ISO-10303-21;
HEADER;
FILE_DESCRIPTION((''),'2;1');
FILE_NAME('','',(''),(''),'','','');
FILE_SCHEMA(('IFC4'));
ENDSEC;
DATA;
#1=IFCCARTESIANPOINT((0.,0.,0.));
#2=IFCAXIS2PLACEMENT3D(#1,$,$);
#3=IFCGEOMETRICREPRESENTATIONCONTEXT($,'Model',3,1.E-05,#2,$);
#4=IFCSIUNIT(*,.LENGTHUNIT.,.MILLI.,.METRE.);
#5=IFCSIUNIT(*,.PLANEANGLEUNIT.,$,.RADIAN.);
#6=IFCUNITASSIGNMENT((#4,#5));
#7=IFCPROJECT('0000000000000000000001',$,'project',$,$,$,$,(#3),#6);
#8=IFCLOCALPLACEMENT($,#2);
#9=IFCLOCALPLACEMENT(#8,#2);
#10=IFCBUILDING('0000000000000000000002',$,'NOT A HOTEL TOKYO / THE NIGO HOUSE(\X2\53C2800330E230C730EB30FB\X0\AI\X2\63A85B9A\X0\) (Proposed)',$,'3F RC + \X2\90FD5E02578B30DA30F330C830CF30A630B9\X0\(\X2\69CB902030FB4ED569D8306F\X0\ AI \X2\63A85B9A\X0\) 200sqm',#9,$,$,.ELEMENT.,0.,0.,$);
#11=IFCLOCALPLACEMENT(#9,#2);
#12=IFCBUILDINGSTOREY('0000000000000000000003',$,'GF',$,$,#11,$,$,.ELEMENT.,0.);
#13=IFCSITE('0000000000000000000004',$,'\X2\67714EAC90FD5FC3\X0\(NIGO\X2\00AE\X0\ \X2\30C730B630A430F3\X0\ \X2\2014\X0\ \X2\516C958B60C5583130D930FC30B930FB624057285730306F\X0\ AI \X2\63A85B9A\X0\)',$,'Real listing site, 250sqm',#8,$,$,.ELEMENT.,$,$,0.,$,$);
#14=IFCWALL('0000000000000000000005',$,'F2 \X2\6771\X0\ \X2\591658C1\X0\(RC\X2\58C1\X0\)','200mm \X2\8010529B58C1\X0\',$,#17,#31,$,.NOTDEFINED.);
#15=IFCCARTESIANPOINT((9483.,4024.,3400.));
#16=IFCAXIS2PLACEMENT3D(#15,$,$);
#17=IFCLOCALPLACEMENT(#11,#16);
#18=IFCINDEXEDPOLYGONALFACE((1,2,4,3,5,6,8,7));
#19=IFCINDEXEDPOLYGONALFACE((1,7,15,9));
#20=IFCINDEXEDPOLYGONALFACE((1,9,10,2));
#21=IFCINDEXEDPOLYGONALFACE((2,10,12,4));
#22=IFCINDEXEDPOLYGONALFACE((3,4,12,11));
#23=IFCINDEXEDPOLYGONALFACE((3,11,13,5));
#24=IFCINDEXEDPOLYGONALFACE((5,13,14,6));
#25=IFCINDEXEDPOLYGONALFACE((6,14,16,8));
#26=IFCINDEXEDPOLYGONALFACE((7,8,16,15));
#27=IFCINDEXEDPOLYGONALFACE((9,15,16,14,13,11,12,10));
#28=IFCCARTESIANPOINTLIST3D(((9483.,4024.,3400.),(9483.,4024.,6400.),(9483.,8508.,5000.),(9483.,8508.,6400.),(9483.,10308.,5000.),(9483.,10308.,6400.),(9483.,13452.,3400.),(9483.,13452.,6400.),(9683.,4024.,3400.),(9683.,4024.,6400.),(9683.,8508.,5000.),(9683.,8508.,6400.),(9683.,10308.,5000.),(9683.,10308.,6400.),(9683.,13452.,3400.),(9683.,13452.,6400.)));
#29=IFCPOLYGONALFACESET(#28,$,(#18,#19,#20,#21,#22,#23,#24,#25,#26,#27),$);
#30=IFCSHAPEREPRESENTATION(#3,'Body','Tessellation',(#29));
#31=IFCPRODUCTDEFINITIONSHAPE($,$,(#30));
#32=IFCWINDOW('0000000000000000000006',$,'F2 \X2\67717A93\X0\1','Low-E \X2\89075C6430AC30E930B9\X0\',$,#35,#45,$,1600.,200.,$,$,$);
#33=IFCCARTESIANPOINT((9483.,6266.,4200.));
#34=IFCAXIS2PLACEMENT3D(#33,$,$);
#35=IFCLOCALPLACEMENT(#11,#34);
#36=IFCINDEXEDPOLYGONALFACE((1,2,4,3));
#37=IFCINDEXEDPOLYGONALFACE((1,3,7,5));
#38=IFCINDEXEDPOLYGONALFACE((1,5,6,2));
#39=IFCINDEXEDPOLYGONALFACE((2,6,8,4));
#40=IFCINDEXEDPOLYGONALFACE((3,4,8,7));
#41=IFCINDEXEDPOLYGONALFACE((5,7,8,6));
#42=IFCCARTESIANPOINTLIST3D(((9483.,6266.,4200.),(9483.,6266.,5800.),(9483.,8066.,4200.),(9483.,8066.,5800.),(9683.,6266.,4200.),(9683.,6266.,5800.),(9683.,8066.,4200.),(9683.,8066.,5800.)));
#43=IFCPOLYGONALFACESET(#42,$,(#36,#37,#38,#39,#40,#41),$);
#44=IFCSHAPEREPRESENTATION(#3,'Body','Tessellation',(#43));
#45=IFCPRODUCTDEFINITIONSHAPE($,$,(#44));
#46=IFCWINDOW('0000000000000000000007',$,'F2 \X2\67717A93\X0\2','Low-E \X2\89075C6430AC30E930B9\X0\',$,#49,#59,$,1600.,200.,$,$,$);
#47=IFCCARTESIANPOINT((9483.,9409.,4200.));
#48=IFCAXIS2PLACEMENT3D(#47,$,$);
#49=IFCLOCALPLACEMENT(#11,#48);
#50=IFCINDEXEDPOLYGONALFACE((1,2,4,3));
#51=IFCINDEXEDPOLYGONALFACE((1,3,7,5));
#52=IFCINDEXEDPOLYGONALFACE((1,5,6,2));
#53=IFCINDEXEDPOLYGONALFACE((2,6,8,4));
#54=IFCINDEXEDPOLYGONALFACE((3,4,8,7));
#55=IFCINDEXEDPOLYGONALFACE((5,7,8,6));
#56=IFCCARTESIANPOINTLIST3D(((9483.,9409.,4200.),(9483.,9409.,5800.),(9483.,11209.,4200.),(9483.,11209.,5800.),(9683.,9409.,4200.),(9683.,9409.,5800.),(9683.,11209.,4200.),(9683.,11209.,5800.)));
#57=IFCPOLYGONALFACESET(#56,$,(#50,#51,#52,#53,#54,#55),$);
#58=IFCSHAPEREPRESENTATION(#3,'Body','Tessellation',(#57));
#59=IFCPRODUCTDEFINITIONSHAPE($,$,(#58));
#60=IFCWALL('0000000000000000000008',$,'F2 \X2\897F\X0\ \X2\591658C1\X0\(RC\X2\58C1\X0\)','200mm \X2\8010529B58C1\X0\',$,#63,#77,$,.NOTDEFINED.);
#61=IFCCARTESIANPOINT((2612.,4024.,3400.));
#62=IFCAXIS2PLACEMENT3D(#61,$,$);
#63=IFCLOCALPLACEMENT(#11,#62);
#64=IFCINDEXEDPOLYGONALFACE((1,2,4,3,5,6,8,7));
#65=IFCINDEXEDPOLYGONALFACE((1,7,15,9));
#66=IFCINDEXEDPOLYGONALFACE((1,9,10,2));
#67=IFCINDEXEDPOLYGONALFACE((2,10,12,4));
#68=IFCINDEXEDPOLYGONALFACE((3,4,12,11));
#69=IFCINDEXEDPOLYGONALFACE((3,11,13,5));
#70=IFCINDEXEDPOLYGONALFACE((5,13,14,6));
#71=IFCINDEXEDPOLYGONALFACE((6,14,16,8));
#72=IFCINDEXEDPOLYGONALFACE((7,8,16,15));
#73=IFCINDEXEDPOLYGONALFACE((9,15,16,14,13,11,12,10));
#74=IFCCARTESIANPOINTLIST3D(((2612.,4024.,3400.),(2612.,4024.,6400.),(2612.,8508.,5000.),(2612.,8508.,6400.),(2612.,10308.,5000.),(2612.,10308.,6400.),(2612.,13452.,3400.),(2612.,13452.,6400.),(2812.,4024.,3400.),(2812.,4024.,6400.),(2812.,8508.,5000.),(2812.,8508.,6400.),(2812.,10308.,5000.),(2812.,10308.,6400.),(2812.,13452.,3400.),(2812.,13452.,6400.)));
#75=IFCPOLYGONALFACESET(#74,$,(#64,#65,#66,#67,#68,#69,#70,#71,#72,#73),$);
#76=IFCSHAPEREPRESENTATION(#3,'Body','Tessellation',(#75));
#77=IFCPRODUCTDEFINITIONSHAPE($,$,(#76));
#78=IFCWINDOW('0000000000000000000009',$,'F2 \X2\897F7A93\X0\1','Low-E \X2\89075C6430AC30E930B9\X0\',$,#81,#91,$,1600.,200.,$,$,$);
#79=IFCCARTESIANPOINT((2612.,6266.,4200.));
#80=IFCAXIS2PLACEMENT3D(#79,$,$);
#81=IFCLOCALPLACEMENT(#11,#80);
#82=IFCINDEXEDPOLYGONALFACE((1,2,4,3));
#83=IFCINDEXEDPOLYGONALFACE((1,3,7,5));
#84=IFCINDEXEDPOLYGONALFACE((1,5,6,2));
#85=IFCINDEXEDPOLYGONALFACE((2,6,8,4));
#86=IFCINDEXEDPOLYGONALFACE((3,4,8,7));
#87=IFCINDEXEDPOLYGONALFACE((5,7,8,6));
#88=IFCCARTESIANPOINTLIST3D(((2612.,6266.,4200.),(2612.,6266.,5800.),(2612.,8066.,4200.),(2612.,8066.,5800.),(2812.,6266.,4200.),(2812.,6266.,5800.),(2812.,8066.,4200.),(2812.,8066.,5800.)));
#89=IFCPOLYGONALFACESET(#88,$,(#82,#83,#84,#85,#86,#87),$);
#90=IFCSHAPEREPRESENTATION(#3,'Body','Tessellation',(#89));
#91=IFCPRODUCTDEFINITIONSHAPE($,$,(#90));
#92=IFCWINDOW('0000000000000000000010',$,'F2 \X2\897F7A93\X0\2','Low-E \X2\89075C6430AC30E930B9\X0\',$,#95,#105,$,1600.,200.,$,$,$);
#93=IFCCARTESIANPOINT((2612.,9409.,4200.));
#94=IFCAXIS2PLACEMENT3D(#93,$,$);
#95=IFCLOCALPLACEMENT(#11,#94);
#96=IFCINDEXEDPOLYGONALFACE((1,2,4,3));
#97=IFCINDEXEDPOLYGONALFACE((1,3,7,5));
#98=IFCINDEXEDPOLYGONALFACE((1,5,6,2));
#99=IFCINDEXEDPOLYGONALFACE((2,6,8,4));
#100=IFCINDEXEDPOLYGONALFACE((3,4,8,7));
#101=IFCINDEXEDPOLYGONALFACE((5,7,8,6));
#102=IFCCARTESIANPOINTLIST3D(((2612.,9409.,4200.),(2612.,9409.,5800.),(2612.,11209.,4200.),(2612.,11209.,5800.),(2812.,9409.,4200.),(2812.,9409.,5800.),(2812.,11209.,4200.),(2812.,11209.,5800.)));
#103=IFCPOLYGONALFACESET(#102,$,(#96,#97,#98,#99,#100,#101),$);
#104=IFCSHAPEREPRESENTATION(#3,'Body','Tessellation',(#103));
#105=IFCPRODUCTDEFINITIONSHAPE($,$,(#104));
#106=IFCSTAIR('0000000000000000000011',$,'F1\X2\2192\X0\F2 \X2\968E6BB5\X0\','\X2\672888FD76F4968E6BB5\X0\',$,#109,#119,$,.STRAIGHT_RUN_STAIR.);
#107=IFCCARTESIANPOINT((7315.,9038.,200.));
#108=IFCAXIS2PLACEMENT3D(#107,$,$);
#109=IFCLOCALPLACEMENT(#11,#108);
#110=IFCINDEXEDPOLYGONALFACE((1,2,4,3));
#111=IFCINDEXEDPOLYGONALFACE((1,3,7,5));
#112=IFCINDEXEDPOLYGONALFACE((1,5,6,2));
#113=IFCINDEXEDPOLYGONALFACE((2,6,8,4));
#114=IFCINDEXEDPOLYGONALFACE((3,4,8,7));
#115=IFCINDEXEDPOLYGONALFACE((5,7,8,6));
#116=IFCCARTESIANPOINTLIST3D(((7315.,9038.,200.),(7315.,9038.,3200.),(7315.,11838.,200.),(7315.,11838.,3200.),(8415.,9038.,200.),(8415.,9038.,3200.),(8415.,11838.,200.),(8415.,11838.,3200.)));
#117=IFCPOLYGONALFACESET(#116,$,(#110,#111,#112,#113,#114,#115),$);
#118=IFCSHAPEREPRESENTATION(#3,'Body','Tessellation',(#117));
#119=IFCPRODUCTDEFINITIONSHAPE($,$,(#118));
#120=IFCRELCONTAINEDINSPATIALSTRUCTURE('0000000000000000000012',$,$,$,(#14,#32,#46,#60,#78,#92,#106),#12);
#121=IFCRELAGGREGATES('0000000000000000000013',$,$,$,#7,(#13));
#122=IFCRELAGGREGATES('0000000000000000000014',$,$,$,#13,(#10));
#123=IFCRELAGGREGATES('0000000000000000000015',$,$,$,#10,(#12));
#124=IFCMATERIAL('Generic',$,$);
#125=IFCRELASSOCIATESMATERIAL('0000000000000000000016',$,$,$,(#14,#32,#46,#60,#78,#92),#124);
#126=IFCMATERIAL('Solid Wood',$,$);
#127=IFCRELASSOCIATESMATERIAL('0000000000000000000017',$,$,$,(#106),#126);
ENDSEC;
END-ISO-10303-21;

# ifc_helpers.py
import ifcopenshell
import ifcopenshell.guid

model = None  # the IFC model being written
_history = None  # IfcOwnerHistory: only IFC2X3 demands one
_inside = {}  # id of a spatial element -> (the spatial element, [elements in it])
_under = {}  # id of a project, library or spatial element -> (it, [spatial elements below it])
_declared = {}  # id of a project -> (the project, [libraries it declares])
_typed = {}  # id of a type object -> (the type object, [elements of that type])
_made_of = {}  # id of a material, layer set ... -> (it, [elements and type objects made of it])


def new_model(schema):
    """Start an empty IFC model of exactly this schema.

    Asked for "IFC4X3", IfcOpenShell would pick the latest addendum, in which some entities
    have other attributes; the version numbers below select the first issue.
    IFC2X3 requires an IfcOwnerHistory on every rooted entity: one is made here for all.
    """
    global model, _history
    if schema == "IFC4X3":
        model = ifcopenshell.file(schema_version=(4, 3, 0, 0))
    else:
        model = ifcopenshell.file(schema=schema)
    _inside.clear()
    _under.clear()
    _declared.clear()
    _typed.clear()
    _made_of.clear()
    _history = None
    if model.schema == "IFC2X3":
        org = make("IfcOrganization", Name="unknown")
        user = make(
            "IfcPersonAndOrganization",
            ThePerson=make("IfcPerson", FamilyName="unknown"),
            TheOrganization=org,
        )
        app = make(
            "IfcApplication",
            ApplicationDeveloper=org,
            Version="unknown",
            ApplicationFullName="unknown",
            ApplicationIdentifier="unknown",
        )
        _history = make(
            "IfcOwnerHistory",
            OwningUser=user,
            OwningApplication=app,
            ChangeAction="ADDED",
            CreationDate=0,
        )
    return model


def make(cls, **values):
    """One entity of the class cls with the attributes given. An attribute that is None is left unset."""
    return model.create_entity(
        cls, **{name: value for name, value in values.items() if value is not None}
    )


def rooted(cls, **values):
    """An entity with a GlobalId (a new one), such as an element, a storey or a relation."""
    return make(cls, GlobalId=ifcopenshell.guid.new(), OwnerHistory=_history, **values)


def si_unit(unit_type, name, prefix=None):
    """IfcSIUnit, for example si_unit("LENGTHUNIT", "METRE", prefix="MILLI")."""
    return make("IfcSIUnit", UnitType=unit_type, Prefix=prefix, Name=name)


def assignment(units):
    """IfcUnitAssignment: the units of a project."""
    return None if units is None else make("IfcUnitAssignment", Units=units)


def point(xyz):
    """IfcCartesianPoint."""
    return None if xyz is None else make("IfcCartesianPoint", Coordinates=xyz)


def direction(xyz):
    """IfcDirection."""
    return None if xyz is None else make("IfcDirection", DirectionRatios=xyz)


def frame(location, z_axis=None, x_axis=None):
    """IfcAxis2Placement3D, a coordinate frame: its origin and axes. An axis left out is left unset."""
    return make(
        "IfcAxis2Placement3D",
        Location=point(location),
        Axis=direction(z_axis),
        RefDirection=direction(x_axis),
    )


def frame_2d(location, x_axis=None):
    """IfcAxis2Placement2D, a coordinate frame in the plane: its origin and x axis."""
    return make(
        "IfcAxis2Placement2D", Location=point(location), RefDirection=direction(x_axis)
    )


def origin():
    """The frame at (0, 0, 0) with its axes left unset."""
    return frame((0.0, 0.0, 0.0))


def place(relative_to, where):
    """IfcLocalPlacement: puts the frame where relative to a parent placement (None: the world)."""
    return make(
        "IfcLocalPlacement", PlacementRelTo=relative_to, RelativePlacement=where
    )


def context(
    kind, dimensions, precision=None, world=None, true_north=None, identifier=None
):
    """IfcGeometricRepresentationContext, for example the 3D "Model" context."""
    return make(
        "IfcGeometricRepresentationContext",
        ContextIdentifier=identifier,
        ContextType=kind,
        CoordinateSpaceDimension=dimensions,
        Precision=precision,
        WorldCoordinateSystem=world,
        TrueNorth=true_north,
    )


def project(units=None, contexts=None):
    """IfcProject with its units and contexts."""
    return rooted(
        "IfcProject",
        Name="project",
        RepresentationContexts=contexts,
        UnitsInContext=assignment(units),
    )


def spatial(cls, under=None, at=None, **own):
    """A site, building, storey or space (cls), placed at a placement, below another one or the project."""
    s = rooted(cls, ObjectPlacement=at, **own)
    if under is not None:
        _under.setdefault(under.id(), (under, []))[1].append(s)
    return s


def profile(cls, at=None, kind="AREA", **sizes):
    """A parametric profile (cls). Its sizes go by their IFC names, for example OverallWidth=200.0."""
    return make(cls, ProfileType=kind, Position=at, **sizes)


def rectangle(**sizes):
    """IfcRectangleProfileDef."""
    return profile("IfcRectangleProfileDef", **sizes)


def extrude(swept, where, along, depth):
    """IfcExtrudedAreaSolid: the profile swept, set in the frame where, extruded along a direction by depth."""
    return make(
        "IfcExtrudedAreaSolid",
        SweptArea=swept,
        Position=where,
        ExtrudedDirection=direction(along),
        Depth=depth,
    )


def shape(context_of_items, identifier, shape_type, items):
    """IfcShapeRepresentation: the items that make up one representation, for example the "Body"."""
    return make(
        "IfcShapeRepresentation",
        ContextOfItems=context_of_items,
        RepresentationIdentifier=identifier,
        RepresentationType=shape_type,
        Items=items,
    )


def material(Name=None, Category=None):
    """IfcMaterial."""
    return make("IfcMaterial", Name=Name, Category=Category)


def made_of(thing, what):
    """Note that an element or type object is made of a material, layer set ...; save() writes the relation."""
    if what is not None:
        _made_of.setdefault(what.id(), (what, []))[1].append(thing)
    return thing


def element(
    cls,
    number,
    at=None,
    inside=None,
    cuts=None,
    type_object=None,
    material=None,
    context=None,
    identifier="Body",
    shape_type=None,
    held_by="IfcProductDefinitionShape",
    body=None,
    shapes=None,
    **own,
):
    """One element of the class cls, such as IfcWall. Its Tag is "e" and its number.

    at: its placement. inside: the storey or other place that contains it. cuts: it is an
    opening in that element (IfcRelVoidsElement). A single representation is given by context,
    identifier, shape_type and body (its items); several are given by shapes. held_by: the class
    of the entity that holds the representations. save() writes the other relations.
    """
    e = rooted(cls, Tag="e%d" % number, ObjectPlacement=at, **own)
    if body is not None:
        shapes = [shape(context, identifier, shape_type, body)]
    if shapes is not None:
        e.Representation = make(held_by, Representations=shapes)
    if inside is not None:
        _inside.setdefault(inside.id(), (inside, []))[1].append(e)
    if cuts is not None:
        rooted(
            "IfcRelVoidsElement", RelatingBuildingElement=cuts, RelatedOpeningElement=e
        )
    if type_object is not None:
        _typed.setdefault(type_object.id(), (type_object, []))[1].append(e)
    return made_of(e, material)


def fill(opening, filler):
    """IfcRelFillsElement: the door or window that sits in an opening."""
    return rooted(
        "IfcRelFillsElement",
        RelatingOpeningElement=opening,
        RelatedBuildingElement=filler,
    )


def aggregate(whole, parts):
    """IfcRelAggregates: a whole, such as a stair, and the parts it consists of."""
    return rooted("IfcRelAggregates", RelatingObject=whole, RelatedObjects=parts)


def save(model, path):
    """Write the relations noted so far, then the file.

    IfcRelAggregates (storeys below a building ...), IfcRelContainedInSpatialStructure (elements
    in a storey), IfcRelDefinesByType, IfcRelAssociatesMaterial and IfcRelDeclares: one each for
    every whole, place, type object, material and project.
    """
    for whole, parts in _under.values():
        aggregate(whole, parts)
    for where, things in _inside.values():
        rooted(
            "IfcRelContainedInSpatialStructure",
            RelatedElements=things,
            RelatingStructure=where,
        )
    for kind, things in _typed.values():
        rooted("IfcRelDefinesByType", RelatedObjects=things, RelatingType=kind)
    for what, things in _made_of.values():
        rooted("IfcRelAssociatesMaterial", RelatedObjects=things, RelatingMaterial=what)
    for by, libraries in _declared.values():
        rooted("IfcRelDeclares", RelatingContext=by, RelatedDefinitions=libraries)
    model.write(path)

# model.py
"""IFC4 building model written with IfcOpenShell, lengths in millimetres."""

from ifc_helpers import new_model, si_unit, frame, frame_2d, origin, place, context, project, spatial, rectangle, extrude, material, element, fill, save


model = new_model("IFC4")

# Units and contexts
model_context = context("Model", 3, precision=1e-05, world=origin())
ifc_project = project(units=[si_unit("LENGTHUNIT", "METRE", prefix="MILLI"), si_unit("PLANEANGLEUNIT", "RADIAN")], contexts=[model_context])

# Site, building, storey
site_placement = place(None, origin())
site = spatial("IfcSite", under=ifc_project, at=site_placement, Name="東京都心(NIGO® デザイン — 公開情報ベース・所在地は AI 推定)", ObjectType="Real listing site, 250sqm", CompositionType="ELEMENT", RefElevation=0.0)
building_placement = place(site_placement, origin())
building = spatial("IfcBuilding", under=site, at=building_placement, Name="NOT A HOTEL TOKYO / THE NIGO HOUSE(参考モデル・AI推定) (Proposed)", ObjectType="3F RC + 都市型ペントハウス(構造・仕様は AI 推定) 200sqm", CompositionType="ELEMENT", ElevationOfRefHeight=0.0, ElevationOfTerrain=0.0)
storey_placement = place(building_placement, origin())
storey = spatial("IfcBuildingStorey", under=building, at=storey_placement, Name="GF", CompositionType="ELEMENT", Elevation=0.0)

# Shared definitions
ifc_material_1 = material(Name="Generic")

# Walls, openings, windows
wall_1_placement = place(storey_placement, frame((9483.0, 4024.0, 3400.0)))
wall_1 = element("IfcWall", 1, at=wall_1_placement, inside=storey, material=ifc_material_1, Name="F2 東 外壁(RC壁)", Description="200mm 耐力壁", PredefinedType="NOTDEFINED", context=model_context, shape_type="SweptSolid", body=[
    extrude(rectangle(XDim=200.0, YDim=9428.0, at=frame_2d((100.0, 4714.0))), frame((9483.0, 4024.0, 3400.0)), (0.0, 0.0, 1.0), 3000.0),
])
opening_1_placement = place(storey_placement, frame((9483.0, 6266.0, 4200.0)))
opening_1 = element("IfcOpeningElement", 2, at=opening_1_placement, cuts=wall_1, PredefinedType="NOTDEFINED", context=model_context, shape_type="SweptSolid", body=[
    extrude(rectangle(XDim=200.0, YDim=1800.0, at=frame_2d((100.0, 900.0))), frame((9483.0, 6266.0, 4200.0)), (0.0, 0.0, 1.0), 1600.0),
])
opening_2_placement = place(storey_placement, frame((9483.0, 9409.0, 4200.0)))
opening_2 = element("IfcOpeningElement", 3, at=opening_2_placement, cuts=wall_1, PredefinedType="NOTDEFINED", context=model_context, shape_type="SweptSolid", body=[
    extrude(rectangle(XDim=200.0, YDim=1800.0, at=frame_2d((100.0, 900.0))), frame((9483.0, 9409.0, 4200.0)), (0.0, 0.0, 1.0), 1600.0),
])
window_1_placement = place(storey_placement, frame((9483.0, 6266.0, 4200.0)))
window_1 = element("IfcWindow", 4, at=window_1_placement, inside=storey, material=ifc_material_1, Name="F2 東窓1", Description="Low-E 複層ガラス", OverallHeight=1600.0, OverallWidth=200.0, context=model_context, shape_type="SweptSolid", body=[
    extrude(rectangle(XDim=200.0, YDim=1800.0, at=frame_2d((100.0, 900.0))), frame((9483.0, 6266.0, 4200.0)), (0.0, 0.0, 1.0), 1600.0),
])
fill(opening_1, window_1)
window_2_placement = place(storey_placement, frame((9483.0, 9409.0, 4200.0)))
window_2 = element("IfcWindow", 5, at=window_2_placement, inside=storey, material=ifc_material_1, Name="F2 東窓2", Description="Low-E 複層ガラス", OverallHeight=1600.0, OverallWidth=200.0, context=model_context, shape_type="SweptSolid", body=[
    extrude(rectangle(XDim=200.0, YDim=1800.0, at=frame_2d((100.0, 900.0))), frame((9483.0, 9409.0, 4200.0)), (0.0, 0.0, 1.0), 1600.0),
])
fill(opening_2, window_2)
wall_2_placement = place(storey_placement, frame((2612.0, 4024.0, 3400.0)))
wall_2 = element("IfcWall", 6, at=wall_2_placement, inside=storey, material=ifc_material_1, Name="F2 西 外壁(RC壁)", Description="200mm 耐力壁", PredefinedType="NOTDEFINED", context=model_context, shape_type="SweptSolid", body=[
    extrude(rectangle(XDim=200.0, YDim=9428.0, at=frame_2d((100.0, 4714.0))), frame((2612.0, 4024.0, 3400.0)), (0.0, 0.0, 1.0), 3000.0),
])
opening_3_placement = place(storey_placement, frame((2612.0, 6266.0, 4200.0)))
opening_3 = element("IfcOpeningElement", 7, at=opening_3_placement, cuts=wall_2, PredefinedType="NOTDEFINED", context=model_context, shape_type="SweptSolid", body=[
    extrude(rectangle(XDim=200.0, YDim=1800.0, at=frame_2d((100.0, 900.0))), frame((2612.0, 6266.0, 4200.0)), (0.0, 0.0, 1.0), 1600.0),
])
opening_4_placement = place(storey_placement, frame((2612.0, 9409.0, 4200.0)))
opening_4 = element("IfcOpeningElement", 8, at=opening_4_placement, cuts=wall_2, PredefinedType="NOTDEFINED", context=model_context, shape_type="SweptSolid", body=[
    extrude(rectangle(XDim=200.0, YDim=1800.0, at=frame_2d((100.0, 900.0))), frame((2612.0, 9409.0, 4200.0)), (0.0, 0.0, 1.0), 1600.0),
])
window_3_placement = place(storey_placement, frame((2612.0, 6266.0, 4200.0)))
window_3 = element("IfcWindow", 9, at=window_3_placement, inside=storey, material=ifc_material_1, Name="F2 西窓1", Description="Low-E 複層ガラス", OverallHeight=1600.0, OverallWidth=200.0, context=model_context, shape_type="SweptSolid", body=[
    extrude(rectangle(XDim=200.0, YDim=1800.0, at=frame_2d((100.0, 900.0))), frame((2612.0, 6266.0, 4200.0)), (0.0, 0.0, 1.0), 1600.0),
])
fill(opening_3, window_3)
window_4_placement = place(storey_placement, frame((2612.0, 9409.0, 4200.0)))
window_4 = element("IfcWindow", 10, at=window_4_placement, inside=storey, material=ifc_material_1, Name="F2 西窓2", Description="Low-E 複層ガラス", OverallHeight=1600.0, OverallWidth=200.0, context=model_context, shape_type="SweptSolid", body=[
    extrude(rectangle(XDim=200.0, YDim=1800.0, at=frame_2d((100.0, 900.0))), frame((2612.0, 9409.0, 4200.0)), (0.0, 0.0, 1.0), 1600.0),
])
fill(opening_4, window_4)

# Stair
ifc_material_2 = material(Name="Solid Wood")
stair_placement = place(storey_placement, frame((7315.0, 9038.0, 200.0)))
element("IfcStair", 11, at=stair_placement, inside=storey, material=ifc_material_2, Name="F1→F2 階段", Description="木製直階段", PredefinedType="STRAIGHT_RUN_STAIR", context=model_context, shape_type="SweptSolid", body=[
    extrude(rectangle(XDim=1100.0, YDim=2800.0, at=frame_2d((550.0, 1400.0))), frame((7315.0, 9038.0, 200.0)), (0.0, 0.0, 1.0), 3000.0),
])

save(model, "model.ifc")
